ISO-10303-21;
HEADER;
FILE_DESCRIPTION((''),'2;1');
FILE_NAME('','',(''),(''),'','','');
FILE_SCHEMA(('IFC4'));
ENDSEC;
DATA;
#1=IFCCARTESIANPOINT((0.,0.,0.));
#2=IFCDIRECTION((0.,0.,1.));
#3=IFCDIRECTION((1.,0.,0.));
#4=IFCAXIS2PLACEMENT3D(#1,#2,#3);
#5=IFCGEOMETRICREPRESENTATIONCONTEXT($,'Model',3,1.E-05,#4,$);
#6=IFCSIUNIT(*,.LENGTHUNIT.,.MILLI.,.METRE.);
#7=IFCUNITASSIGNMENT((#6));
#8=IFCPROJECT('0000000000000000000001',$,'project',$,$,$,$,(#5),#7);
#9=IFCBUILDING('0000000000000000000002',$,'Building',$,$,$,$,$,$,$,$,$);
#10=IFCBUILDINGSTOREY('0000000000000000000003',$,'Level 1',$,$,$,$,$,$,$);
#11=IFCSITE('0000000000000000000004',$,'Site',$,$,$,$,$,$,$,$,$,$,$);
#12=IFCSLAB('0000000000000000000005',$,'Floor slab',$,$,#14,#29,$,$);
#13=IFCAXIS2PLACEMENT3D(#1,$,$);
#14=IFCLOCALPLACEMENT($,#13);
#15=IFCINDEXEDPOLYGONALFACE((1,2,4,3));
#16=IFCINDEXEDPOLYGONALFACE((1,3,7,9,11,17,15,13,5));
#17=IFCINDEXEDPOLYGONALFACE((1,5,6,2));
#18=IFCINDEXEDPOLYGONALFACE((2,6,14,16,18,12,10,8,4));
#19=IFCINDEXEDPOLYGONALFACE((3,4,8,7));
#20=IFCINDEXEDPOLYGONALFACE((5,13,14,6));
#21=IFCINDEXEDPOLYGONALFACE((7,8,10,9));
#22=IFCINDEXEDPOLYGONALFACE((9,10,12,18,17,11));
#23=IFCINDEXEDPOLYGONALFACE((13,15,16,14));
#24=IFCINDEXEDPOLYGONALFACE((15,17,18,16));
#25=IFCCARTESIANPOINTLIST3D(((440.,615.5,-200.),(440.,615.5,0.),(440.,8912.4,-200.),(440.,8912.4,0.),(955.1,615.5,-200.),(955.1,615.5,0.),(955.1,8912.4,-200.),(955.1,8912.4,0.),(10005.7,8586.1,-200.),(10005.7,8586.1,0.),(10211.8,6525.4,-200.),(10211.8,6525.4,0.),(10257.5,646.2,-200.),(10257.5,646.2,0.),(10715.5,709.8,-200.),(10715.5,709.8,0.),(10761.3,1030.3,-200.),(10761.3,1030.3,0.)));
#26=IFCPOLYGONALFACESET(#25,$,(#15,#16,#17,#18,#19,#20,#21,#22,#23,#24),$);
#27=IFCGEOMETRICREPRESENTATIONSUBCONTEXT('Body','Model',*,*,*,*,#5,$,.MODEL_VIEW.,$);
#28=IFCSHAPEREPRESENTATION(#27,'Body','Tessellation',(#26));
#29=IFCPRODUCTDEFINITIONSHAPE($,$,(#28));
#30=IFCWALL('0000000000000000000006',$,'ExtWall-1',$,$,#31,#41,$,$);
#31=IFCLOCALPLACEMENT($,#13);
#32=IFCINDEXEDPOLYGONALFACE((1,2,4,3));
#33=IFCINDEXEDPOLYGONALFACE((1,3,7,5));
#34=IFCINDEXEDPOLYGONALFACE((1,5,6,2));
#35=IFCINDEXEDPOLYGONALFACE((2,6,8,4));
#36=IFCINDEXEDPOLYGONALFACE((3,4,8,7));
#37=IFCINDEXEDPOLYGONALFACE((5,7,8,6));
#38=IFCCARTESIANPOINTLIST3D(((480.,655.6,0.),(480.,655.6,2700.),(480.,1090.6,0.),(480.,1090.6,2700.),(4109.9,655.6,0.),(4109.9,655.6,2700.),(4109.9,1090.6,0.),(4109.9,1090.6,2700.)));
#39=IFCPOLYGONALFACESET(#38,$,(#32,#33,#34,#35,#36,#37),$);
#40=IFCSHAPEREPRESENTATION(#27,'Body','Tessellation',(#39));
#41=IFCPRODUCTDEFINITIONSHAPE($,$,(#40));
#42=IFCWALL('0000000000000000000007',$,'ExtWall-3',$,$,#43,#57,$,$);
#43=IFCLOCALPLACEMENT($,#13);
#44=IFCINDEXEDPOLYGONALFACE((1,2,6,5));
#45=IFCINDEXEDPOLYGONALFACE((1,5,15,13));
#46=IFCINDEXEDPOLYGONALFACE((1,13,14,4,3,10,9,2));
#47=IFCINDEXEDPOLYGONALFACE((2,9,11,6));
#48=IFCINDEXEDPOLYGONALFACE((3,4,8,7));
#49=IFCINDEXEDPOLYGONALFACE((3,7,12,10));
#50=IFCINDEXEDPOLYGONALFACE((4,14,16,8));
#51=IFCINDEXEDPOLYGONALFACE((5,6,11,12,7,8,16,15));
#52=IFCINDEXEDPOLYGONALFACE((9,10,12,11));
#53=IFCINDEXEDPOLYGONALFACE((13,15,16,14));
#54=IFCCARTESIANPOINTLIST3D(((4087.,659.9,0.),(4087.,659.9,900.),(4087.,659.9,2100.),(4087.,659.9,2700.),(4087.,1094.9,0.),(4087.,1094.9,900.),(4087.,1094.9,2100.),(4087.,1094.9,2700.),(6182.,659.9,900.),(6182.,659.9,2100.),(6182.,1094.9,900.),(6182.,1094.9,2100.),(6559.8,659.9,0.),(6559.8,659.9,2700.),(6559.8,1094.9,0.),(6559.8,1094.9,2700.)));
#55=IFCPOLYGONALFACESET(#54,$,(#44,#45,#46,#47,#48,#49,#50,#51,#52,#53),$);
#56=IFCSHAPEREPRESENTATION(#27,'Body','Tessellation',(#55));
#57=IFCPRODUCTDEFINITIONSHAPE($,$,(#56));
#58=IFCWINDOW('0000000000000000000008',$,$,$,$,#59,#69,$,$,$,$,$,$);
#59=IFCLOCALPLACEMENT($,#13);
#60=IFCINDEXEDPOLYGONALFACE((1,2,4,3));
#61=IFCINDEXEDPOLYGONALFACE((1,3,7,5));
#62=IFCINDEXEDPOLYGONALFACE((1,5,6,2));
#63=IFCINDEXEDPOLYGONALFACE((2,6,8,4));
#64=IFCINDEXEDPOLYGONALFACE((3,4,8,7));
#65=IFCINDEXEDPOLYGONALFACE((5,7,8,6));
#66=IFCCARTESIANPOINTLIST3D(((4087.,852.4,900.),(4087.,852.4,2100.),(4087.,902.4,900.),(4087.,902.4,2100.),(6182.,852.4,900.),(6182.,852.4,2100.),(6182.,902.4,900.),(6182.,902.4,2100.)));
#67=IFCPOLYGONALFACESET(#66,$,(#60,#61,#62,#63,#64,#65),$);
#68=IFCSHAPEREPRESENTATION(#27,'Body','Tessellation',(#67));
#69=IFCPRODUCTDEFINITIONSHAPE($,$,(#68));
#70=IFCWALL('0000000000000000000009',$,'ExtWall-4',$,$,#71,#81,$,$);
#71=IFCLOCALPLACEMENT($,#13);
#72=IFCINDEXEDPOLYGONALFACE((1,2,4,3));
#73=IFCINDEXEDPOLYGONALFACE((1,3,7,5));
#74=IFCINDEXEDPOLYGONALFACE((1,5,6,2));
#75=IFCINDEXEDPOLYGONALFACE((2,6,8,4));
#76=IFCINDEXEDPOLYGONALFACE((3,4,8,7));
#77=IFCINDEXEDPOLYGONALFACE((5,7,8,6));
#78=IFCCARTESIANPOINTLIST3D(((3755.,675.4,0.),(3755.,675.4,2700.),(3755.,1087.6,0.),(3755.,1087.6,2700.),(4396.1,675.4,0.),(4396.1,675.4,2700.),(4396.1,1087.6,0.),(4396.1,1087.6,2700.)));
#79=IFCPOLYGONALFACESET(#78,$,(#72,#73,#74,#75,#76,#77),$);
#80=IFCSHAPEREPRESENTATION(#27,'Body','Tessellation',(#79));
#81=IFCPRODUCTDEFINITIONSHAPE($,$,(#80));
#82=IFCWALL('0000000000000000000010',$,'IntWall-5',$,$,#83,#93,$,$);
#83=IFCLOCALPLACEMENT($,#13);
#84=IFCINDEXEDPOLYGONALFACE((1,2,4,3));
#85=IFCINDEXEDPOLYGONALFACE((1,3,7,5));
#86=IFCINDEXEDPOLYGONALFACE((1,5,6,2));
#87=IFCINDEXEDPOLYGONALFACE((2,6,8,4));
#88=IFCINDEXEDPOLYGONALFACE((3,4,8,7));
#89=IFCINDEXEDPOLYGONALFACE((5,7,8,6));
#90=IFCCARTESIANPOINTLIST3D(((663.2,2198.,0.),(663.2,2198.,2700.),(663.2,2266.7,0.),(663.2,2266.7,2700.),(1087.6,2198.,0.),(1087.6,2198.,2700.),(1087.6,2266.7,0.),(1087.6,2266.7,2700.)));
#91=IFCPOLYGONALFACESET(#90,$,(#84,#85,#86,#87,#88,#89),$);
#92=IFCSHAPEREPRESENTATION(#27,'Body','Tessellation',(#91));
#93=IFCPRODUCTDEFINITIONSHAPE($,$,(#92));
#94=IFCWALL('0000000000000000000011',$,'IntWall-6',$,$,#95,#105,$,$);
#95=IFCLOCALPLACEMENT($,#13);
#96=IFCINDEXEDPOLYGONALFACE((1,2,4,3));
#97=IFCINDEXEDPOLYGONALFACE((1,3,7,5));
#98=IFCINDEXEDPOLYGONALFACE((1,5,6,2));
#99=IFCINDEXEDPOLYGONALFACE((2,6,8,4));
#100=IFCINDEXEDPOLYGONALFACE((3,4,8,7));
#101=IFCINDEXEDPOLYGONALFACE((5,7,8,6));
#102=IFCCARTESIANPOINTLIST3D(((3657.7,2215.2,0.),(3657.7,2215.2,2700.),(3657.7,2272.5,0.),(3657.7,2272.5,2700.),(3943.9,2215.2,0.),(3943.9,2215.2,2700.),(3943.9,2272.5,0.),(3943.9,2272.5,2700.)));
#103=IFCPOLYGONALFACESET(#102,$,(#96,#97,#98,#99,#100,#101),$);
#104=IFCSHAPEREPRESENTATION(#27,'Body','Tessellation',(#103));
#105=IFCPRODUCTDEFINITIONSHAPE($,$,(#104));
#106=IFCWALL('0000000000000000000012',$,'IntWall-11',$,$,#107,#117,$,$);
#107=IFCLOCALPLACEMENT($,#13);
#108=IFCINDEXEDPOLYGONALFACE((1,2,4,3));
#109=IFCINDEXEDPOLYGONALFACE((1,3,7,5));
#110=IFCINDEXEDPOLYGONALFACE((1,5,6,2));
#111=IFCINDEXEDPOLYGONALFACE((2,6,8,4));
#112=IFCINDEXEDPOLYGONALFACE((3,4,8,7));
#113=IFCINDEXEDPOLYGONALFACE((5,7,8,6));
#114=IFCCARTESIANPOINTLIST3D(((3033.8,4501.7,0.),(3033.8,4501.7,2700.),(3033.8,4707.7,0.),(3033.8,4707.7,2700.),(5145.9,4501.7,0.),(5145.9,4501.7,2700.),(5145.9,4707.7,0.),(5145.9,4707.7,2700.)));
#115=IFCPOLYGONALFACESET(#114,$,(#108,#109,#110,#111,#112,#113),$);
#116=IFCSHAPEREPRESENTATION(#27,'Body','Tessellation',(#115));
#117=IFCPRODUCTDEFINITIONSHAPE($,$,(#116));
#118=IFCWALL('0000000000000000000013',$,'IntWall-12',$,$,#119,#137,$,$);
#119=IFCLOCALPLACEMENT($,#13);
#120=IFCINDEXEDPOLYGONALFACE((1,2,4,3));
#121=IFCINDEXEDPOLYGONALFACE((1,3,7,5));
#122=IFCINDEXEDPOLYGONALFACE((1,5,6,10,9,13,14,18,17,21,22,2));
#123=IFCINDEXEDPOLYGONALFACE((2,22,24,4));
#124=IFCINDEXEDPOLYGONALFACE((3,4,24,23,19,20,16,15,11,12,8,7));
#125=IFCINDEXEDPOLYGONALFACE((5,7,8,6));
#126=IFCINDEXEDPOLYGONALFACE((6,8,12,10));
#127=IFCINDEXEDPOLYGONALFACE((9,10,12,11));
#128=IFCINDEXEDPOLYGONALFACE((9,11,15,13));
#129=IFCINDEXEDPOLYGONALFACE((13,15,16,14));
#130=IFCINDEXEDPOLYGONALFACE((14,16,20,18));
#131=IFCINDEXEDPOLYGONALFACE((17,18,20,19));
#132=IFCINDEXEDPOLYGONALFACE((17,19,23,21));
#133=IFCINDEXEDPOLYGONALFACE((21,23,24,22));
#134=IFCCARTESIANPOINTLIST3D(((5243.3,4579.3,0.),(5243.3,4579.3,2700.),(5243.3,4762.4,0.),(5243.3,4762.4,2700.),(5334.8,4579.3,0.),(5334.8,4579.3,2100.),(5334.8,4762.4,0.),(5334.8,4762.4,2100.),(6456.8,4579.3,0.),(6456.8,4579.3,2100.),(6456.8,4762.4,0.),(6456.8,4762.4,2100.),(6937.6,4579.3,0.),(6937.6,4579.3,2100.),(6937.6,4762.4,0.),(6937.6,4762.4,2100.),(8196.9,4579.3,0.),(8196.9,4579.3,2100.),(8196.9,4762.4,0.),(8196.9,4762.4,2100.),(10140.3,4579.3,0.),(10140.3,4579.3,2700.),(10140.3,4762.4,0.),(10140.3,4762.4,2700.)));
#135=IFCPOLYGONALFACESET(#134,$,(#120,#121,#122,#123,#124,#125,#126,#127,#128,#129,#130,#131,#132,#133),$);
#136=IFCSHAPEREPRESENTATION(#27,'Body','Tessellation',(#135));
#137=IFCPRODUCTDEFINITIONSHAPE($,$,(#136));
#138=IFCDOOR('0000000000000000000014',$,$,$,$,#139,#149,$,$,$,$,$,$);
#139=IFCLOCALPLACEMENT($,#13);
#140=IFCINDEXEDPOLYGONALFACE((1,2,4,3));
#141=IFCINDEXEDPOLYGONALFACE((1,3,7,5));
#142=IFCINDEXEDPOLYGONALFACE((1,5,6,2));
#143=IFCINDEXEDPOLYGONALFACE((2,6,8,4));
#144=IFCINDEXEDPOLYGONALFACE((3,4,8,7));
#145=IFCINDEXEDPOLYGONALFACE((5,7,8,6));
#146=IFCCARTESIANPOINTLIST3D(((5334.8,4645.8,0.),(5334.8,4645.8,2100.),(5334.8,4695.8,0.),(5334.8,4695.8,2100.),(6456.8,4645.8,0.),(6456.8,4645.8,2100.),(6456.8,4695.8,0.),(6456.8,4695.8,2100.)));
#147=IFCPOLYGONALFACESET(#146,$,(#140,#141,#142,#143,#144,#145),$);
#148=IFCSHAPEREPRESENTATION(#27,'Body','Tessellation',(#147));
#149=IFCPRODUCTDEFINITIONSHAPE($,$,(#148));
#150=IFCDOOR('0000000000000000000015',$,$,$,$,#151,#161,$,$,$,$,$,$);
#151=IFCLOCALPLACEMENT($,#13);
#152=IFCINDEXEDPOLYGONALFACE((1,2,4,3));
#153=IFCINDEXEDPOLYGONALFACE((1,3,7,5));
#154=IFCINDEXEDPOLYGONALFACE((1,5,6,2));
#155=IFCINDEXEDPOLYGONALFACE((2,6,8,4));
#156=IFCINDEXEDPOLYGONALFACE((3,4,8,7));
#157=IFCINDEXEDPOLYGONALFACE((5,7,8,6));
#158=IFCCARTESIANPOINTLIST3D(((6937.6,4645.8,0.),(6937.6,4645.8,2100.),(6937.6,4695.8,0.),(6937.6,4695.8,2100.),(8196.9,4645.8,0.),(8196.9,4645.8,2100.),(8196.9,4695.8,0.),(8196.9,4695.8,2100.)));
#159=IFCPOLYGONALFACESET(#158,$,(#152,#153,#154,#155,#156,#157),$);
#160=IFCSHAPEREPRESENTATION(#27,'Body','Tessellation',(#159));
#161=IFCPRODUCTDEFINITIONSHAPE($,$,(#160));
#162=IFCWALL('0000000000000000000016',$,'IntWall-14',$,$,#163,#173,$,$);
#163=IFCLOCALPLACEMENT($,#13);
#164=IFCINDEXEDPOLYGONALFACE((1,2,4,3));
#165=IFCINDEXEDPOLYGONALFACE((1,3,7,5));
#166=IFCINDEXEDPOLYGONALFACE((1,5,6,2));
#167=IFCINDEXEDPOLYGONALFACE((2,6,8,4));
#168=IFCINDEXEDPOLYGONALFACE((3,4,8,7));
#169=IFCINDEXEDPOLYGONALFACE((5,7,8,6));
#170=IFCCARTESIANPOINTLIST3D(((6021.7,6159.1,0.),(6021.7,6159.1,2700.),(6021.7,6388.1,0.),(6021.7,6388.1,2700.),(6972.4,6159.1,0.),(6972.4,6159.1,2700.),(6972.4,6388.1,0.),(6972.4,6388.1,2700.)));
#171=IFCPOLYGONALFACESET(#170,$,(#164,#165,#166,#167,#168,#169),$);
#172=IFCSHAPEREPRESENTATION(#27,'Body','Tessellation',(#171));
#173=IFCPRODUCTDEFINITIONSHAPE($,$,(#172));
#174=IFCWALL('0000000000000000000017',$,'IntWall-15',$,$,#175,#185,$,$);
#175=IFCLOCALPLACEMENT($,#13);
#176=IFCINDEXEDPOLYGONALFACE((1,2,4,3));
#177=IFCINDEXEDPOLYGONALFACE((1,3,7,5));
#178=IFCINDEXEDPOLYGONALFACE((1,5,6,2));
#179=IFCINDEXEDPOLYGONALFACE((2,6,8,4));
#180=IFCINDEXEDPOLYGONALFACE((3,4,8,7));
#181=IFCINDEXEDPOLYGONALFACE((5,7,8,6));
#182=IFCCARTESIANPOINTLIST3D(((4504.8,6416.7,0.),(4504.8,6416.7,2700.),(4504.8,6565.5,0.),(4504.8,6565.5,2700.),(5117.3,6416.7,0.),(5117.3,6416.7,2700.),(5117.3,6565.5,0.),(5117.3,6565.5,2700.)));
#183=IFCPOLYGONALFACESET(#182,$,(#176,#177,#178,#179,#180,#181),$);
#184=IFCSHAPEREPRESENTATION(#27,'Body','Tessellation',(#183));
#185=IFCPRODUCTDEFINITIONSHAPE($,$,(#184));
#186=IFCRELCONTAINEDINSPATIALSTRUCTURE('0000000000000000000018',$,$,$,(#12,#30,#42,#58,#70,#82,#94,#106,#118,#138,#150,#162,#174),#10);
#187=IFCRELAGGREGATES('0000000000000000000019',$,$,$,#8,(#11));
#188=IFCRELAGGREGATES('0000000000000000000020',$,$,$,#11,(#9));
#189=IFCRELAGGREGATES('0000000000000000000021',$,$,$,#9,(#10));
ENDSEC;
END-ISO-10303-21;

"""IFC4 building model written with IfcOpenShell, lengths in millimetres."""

from ifc_helpers import new_model, si_unit, frame, origin_with_axes, place, context, subcontext, project, spatial, indexed_curve, outline, extrude, element, fill, save


model = new_model("IFC4")

# Units and contexts
model_context = context("Model", 3, precision=1e-05, world=origin_with_axes())
body_context = subcontext(model_context, "Body", "Model", "MODEL_VIEW")
ifc_project = project(units=[si_unit("LENGTHUNIT", "METRE", prefix="MILLI")], contexts=[model_context])

# Site, building, storey
site = spatial("IfcSite", under=ifc_project, Name="Site")
building = spatial("IfcBuilding", under=site, Name="Building")
storey = spatial("IfcBuildingStorey", under=building, Name="Level 1")

# Slab
slab_placement = place(None, frame((0.0, 0.0, -200.0), z_axis=(0.0, 0.0, 1.0), x_axis=(1.0, 0.0, 0.0)))
element("IfcSlab", 1, at=slab_placement, inside=storey, Name="Floor slab", context=body_context, shape_type="SweptSolid", body=[
    extrude(outline(indexed_curve([(440.0, 615.5), (440.0, 8912.4), (955.1, 8912.4), (10005.7, 8586.1), (10211.8, 6525.4), (10761.3, 1030.3), (10715.5, 709.8), (10257.5, 646.2), (955.1, 615.5)])), None, (0.0, 0.0, 1.0), 200.0),
])

# Wall
wall_1_placement = place(None, frame((480.0, 873.1, 0.0), z_axis=(0.0, 0.0, 1.0), x_axis=(1.0, 0.0, 0.0)))
element("IfcWall", 2, at=wall_1_placement, inside=storey, Name="ExtWall-1", context=body_context, shape_type="SweptSolid", body=[
    extrude(outline(indexed_curve([(0.0, 0.0), (0.0, 435.0), (3629.9, 435.0), (3629.9, 0.0), (0.0, 0.0)], self_intersect=False)), frame((0.0, -217.5, 0.0), z_axis=(0.0, 0.0, 1.0), x_axis=(1.0, 0.0, 0.0)), (0.0, 0.0, 1.0), 2700.0),
])

# Wall, opening, window
wall_2_placement = place(None, frame((4087.0, 877.4, 0.0), z_axis=(0.0, 0.0, 1.0), x_axis=(1.0, 0.0, 0.0)))
wall_2 = element("IfcWall", 3, at=wall_2_placement, inside=storey, Name="ExtWall-3", context=body_context, shape_type="SweptSolid", body=[
    extrude(outline(indexed_curve([(0.0, 0.0), (0.0, 435.0), (2472.8, 435.0), (2472.8, 0.0), (0.0, 0.0)], self_intersect=False)), frame((0.0, -217.5, 0.0), z_axis=(0.0, 0.0, 1.0), x_axis=(1.0, 0.0, 0.0)), (0.0, 0.0, 1.0), 2700.0),
])
opening_1_placement = place(wall_2_placement, frame((0.0, 0.0, 900.0), z_axis=(0.0, 0.0, 1.0), x_axis=(1.0, 0.0, 0.0)))
opening_1 = element("IfcOpeningElement", 4, at=opening_1_placement, cuts=wall_2, context=body_context, shape_type="SweptSolid", body=[
    extrude(outline(indexed_curve([(0.0, 0.0), (0.0, 535.0), (2095.0, 535.0), (2095.0, 0.0), (0.0, 0.0)], self_intersect=False)), frame((0.0, -267.5, 0.0), z_axis=(0.0, 0.0, 1.0), x_axis=(1.0, 0.0, 0.0)), (0.0, 0.0, 1.0), 1200.0),
])
window_1_placement = place(opening_1_placement, origin_with_axes())
window_1 = element("IfcWindow", 5, at=window_1_placement, inside=storey, context=body_context, shape_type="SweptSolid", body=[
    extrude(outline(indexed_curve([(0.0, 0.0), (0.0, 50.0), (2095.0, 50.0), (2095.0, 0.0), (0.0, 0.0)], self_intersect=False)), frame((0.0, -25.0, 0.0), z_axis=(0.0, 0.0, 1.0), x_axis=(1.0, 0.0, 0.0)), (0.0, 0.0, 1.0), 1200.0),
])
fill(opening_1, window_1)

# Walls
wall_3_placement = place(None, frame((3755.0, 881.5, 0.0), z_axis=(0.0, 0.0, 1.0), x_axis=(1.0, 0.0, 0.0)))
element("IfcWall", 6, at=wall_3_placement, inside=storey, Name="ExtWall-4", context=body_context, shape_type="SweptSolid", body=[
    extrude(outline(indexed_curve([(0.0, 0.0), (0.0, 412.1), (641.1, 412.1), (641.1, 0.0), (0.0, 0.0)], self_intersect=False)), frame((0.0, -206.1, 0.0), z_axis=(0.0, 0.0, 1.0), x_axis=(1.0, 0.0, 0.0)), (0.0, 0.0, 1.0), 2700.0),
])
wall_4_placement = place(None, frame((663.2, 2232.4, 0.0), z_axis=(0.0, 0.0, 1.0), x_axis=(1.0, 0.0, 0.0)))
element("IfcWall", 7, at=wall_4_placement, inside=storey, Name="IntWall-5", context=body_context, shape_type="SweptSolid", body=[
    extrude(outline(indexed_curve([(0.0, 0.0), (0.0, 68.7), (424.4, 68.7), (424.4, 0.0), (0.0, 0.0)], self_intersect=False)), frame((0.0, -34.3, 0.0), z_axis=(0.0, 0.0, 1.0), x_axis=(1.0, 0.0, 0.0)), (0.0, 0.0, 1.0), 2700.0),
])
wall_5_placement = place(None, frame((3657.7, 2243.8, 0.0), z_axis=(0.0, 0.0, 1.0), x_axis=(1.0, 0.0, 0.0)))
element("IfcWall", 8, at=wall_5_placement, inside=storey, Name="IntWall-6", context=body_context, shape_type="SweptSolid", body=[
    extrude(outline(indexed_curve([(0.0, 0.0), (0.0, 57.2), (286.2, 57.2), (286.2, 0.0), (0.0, 0.0)], self_intersect=False)), frame((0.0, -28.6, 0.0), z_axis=(0.0, 0.0, 1.0), x_axis=(1.0, 0.0, 0.0)), (0.0, 0.0, 1.0), 2700.0),
])
wall_6_placement = place(None, frame((3033.8, 4604.7, 0.0), z_axis=(0.0, 0.0, 1.0), x_axis=(1.0, 0.0, 0.0)))
element("IfcWall", 9, at=wall_6_placement, inside=storey, Name="IntWall-11", context=body_context, shape_type="SweptSolid", body=[
    extrude(outline(indexed_curve([(0.0, 0.0), (0.0, 206.1), (2112.2, 206.1), (2112.2, 0.0), (0.0, 0.0)], self_intersect=False)), frame((0.0, -103.0, 0.0), z_axis=(0.0, 0.0, 1.0), x_axis=(1.0, 0.0, 0.0)), (0.0, 0.0, 1.0), 2700.0),
])

# Wall, openings, doors
wall_7_placement = place(None, frame((5243.3, 4670.8, 0.0), z_axis=(0.0, 0.0, 1.0), x_axis=(1.0, 0.0, 0.0)))
wall_7 = element("IfcWall", 10, at=wall_7_placement, inside=storey, Name="IntWall-12", context=body_context, shape_type="SweptSolid", body=[
    extrude(outline(indexed_curve([(0.0, 0.0), (0.0, 183.2), (4897.1, 183.2), (4897.1, 0.0), (0.0, 0.0)], self_intersect=False)), frame((0.0, -91.6, 0.0), z_axis=(0.0, 0.0, 1.0), x_axis=(1.0, 0.0, 0.0)), (0.0, 0.0, 1.0), 2700.0),
])
opening_2_placement = place(wall_7_placement, frame((91.6, 0.0, 0.0), z_axis=(0.0, 0.0, 1.0), x_axis=(1.0, 0.0, 0.0)))
opening_2 = element("IfcOpeningElement", 11, at=opening_2_placement, cuts=wall_7, context=body_context, shape_type="SweptSolid", body=[
    extrude(outline(indexed_curve([(0.0, 0.0), (0.0, 283.2), (1121.9, 283.2), (1121.9, 0.0), (0.0, 0.0)], self_intersect=False)), frame((0.0, -141.6, 0.0), z_axis=(0.0, 0.0, 1.0), x_axis=(1.0, 0.0, 0.0)), (0.0, 0.0, 1.0), 2100.0),
])
opening_3_placement = place(wall_7_placement, frame((1694.3, 0.0, 0.0), z_axis=(0.0, 0.0, 1.0), x_axis=(1.0, 0.0, 0.0)))
opening_3 = element("IfcOpeningElement", 12, at=opening_3_placement, cuts=wall_7, context=body_context, shape_type="SweptSolid", body=[
    extrude(outline(indexed_curve([(0.0, 0.0), (0.0, 283.2), (1259.3, 283.2), (1259.3, 0.0), (0.0, 0.0)], self_intersect=False)), frame((0.0, -141.6, 0.0), z_axis=(0.0, 0.0, 1.0), x_axis=(1.0, 0.0, 0.0)), (0.0, 0.0, 1.0), 2100.0),
])
door_1_placement = place(opening_2_placement, frame((0.0, 0.0, 0.0), z_axis=(0.0, 0.0, 1.0), x_axis=(1.0, 0.0, 0.0)))
door_1 = element("IfcDoor", 13, at=door_1_placement, inside=storey, context=body_context, shape_type="SweptSolid", body=[
    extrude(outline(indexed_curve([(0.0, 0.0), (0.0, 50.0), (1121.9, 50.0), (1121.9, 0.0), (0.0, 0.0)], self_intersect=False)), frame((0.0, -25.0, 0.0), z_axis=(0.0, 0.0, 1.0), x_axis=(1.0, 0.0, 0.0)), (0.0, 0.0, 1.0), 2100.0),
])
fill(opening_2, door_1)
door_2_placement = place(opening_3_placement, origin_with_axes())
door_2 = element("IfcDoor", 14, at=door_2_placement, inside=storey, context=body_context, shape_type="SweptSolid", body=[
    extrude(outline(indexed_curve([(0.0, 0.0), (0.0, 50.0), (1259.3, 50.0), (1259.3, 0.0), (0.0, 0.0)], self_intersect=False)), frame((0.0, -25.0, 0.0), z_axis=(0.0, 0.0, 1.0), x_axis=(1.0, 0.0, 0.0)), (0.0, 0.0, 1.0), 2100.0),
])
fill(opening_3, door_2)

# Walls
wall_8_placement = place(None, frame((6021.7, 6273.6, 0.0), z_axis=(0.0, 0.0, 1.0), x_axis=(1.0, 0.0, 0.0)))
element("IfcWall", 15, at=wall_8_placement, inside=storey, Name="IntWall-14", context=body_context, shape_type="SweptSolid", body=[
    extrude(outline(indexed_curve([(0.0, 0.0), (0.0, 229.0), (950.7, 229.0), (950.7, 0.0), (0.0, 0.0)], self_intersect=False)), frame((0.0, -114.5, 0.0), z_axis=(0.0, 0.0, 1.0), x_axis=(1.0, 0.0, 0.0)), (0.0, 0.0, 1.0), 2700.0),
])
wall_9_placement = place(None, frame((4504.8, 6491.1, 0.0), z_axis=(0.0, 0.0, 1.0), x_axis=(1.0, 0.0, 0.0)))
element("IfcWall", 16, at=wall_9_placement, inside=storey, Name="IntWall-15", context=body_context, shape_type="SweptSolid", body=[
    extrude(outline(indexed_curve([(0.0, 0.0), (0.0, 148.8), (612.5, 148.8), (612.5, 0.0), (0.0, 0.0)], self_intersect=False)), frame((0.0, -74.4, 0.0), z_axis=(0.0, 0.0, 1.0), x_axis=(1.0, 0.0, 0.0)), (0.0, 0.0, 1.0), 2700.0),
])

save(model, "model.ifc")
